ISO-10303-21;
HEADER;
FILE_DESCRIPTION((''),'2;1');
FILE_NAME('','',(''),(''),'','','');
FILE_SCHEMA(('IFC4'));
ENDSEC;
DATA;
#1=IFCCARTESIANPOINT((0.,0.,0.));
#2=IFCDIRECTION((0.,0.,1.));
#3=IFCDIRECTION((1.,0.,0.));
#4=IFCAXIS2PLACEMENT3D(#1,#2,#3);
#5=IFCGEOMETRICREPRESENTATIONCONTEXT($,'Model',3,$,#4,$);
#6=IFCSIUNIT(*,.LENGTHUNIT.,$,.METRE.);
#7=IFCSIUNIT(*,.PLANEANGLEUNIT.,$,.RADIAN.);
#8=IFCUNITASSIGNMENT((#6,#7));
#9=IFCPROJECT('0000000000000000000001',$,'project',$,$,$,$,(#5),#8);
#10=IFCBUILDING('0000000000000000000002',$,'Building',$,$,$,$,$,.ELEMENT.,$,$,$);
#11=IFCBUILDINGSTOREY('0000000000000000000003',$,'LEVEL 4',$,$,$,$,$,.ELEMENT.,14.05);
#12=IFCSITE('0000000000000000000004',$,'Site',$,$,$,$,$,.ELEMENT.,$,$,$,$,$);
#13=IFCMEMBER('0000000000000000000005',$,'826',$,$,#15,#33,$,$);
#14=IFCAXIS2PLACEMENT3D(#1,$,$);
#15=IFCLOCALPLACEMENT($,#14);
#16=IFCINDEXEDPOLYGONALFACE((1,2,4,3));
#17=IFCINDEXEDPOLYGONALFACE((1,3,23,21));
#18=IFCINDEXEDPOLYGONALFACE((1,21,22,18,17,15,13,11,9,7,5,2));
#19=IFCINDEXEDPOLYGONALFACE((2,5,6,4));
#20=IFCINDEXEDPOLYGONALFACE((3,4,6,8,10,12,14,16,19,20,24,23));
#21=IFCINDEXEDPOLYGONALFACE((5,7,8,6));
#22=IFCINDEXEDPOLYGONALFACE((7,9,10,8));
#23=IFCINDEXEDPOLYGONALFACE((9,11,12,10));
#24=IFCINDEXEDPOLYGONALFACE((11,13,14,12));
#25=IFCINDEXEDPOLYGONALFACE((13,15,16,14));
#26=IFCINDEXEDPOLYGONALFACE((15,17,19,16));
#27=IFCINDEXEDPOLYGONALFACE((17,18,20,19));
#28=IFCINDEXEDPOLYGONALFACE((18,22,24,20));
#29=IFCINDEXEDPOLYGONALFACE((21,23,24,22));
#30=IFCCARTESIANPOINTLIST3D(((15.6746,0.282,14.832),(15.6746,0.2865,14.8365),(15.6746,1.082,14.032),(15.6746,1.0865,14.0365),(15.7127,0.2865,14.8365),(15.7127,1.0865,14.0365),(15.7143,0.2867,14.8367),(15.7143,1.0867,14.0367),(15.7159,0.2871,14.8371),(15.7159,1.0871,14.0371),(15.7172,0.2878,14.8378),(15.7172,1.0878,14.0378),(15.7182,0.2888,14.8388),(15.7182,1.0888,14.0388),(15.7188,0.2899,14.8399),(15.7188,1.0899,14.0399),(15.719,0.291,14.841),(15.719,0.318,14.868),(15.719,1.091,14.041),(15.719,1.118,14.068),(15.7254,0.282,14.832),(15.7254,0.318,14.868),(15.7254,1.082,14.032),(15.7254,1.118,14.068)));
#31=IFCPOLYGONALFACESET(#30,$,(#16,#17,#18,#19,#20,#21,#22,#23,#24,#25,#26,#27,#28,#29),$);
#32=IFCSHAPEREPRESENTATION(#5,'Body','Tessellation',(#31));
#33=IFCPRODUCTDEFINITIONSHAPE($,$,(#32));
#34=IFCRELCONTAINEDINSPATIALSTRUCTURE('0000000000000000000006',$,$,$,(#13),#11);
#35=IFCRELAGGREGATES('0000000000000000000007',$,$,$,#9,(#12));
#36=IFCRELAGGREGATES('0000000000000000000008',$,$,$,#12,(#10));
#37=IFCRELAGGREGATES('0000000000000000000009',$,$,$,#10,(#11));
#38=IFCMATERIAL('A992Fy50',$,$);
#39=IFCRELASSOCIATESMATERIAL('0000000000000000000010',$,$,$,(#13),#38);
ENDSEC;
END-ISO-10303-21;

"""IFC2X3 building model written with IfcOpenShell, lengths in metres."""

from ifc_helpers import new_model, si_unit, frame, origin_with_axes, origin_2d_with_axis, place, context, project, spatial, l_section, extrude, material, element, save


model = new_model("IFC2X3")

# Units and contexts
model_context = context("Model", 3, world=origin_with_axes())
ifc_project = project(units=[si_unit("LENGTHUNIT", "METRE"), si_unit("PLANEANGLEUNIT", "RADIAN")], contexts=[model_context])

# Site, building, storey
site = spatial("IfcSite", under=ifc_project, Name="Site", CompositionType="ELEMENT")
building = spatial("IfcBuilding", under=site, Name="Building", CompositionType="ELEMENT")
storey = spatial("IfcBuildingStorey", under=building, Name="LEVEL 4", CompositionType="ELEMENT", Elevation=14.05)

# Shared definitions
ifc_material = material(Name="A992Fy50")

# Member
for number, where, z_axis, x_axis, name in (
    (1, (15.7, 0.3, 14.85), (0.0, 0.707107, -0.707107), (-1.0, 0.0, 0.0), "826"),
):
    element("IfcMember", number, at=place(None, frame(where, z_axis=z_axis, x_axis=x_axis)), inside=storey, material=ifc_material, Name=name, context=model_context, shape_type="SweptSolid", body=[
        extrude(l_section(Depth=0.0508, Width=0.0508, Thickness=0.0063, FilletRadius=0.0063, at=origin_2d_with_axis()), origin_with_axes(), (0.0, 0.0, 1.0), 1.1314),
    ])

save(model, "model.ifc")
